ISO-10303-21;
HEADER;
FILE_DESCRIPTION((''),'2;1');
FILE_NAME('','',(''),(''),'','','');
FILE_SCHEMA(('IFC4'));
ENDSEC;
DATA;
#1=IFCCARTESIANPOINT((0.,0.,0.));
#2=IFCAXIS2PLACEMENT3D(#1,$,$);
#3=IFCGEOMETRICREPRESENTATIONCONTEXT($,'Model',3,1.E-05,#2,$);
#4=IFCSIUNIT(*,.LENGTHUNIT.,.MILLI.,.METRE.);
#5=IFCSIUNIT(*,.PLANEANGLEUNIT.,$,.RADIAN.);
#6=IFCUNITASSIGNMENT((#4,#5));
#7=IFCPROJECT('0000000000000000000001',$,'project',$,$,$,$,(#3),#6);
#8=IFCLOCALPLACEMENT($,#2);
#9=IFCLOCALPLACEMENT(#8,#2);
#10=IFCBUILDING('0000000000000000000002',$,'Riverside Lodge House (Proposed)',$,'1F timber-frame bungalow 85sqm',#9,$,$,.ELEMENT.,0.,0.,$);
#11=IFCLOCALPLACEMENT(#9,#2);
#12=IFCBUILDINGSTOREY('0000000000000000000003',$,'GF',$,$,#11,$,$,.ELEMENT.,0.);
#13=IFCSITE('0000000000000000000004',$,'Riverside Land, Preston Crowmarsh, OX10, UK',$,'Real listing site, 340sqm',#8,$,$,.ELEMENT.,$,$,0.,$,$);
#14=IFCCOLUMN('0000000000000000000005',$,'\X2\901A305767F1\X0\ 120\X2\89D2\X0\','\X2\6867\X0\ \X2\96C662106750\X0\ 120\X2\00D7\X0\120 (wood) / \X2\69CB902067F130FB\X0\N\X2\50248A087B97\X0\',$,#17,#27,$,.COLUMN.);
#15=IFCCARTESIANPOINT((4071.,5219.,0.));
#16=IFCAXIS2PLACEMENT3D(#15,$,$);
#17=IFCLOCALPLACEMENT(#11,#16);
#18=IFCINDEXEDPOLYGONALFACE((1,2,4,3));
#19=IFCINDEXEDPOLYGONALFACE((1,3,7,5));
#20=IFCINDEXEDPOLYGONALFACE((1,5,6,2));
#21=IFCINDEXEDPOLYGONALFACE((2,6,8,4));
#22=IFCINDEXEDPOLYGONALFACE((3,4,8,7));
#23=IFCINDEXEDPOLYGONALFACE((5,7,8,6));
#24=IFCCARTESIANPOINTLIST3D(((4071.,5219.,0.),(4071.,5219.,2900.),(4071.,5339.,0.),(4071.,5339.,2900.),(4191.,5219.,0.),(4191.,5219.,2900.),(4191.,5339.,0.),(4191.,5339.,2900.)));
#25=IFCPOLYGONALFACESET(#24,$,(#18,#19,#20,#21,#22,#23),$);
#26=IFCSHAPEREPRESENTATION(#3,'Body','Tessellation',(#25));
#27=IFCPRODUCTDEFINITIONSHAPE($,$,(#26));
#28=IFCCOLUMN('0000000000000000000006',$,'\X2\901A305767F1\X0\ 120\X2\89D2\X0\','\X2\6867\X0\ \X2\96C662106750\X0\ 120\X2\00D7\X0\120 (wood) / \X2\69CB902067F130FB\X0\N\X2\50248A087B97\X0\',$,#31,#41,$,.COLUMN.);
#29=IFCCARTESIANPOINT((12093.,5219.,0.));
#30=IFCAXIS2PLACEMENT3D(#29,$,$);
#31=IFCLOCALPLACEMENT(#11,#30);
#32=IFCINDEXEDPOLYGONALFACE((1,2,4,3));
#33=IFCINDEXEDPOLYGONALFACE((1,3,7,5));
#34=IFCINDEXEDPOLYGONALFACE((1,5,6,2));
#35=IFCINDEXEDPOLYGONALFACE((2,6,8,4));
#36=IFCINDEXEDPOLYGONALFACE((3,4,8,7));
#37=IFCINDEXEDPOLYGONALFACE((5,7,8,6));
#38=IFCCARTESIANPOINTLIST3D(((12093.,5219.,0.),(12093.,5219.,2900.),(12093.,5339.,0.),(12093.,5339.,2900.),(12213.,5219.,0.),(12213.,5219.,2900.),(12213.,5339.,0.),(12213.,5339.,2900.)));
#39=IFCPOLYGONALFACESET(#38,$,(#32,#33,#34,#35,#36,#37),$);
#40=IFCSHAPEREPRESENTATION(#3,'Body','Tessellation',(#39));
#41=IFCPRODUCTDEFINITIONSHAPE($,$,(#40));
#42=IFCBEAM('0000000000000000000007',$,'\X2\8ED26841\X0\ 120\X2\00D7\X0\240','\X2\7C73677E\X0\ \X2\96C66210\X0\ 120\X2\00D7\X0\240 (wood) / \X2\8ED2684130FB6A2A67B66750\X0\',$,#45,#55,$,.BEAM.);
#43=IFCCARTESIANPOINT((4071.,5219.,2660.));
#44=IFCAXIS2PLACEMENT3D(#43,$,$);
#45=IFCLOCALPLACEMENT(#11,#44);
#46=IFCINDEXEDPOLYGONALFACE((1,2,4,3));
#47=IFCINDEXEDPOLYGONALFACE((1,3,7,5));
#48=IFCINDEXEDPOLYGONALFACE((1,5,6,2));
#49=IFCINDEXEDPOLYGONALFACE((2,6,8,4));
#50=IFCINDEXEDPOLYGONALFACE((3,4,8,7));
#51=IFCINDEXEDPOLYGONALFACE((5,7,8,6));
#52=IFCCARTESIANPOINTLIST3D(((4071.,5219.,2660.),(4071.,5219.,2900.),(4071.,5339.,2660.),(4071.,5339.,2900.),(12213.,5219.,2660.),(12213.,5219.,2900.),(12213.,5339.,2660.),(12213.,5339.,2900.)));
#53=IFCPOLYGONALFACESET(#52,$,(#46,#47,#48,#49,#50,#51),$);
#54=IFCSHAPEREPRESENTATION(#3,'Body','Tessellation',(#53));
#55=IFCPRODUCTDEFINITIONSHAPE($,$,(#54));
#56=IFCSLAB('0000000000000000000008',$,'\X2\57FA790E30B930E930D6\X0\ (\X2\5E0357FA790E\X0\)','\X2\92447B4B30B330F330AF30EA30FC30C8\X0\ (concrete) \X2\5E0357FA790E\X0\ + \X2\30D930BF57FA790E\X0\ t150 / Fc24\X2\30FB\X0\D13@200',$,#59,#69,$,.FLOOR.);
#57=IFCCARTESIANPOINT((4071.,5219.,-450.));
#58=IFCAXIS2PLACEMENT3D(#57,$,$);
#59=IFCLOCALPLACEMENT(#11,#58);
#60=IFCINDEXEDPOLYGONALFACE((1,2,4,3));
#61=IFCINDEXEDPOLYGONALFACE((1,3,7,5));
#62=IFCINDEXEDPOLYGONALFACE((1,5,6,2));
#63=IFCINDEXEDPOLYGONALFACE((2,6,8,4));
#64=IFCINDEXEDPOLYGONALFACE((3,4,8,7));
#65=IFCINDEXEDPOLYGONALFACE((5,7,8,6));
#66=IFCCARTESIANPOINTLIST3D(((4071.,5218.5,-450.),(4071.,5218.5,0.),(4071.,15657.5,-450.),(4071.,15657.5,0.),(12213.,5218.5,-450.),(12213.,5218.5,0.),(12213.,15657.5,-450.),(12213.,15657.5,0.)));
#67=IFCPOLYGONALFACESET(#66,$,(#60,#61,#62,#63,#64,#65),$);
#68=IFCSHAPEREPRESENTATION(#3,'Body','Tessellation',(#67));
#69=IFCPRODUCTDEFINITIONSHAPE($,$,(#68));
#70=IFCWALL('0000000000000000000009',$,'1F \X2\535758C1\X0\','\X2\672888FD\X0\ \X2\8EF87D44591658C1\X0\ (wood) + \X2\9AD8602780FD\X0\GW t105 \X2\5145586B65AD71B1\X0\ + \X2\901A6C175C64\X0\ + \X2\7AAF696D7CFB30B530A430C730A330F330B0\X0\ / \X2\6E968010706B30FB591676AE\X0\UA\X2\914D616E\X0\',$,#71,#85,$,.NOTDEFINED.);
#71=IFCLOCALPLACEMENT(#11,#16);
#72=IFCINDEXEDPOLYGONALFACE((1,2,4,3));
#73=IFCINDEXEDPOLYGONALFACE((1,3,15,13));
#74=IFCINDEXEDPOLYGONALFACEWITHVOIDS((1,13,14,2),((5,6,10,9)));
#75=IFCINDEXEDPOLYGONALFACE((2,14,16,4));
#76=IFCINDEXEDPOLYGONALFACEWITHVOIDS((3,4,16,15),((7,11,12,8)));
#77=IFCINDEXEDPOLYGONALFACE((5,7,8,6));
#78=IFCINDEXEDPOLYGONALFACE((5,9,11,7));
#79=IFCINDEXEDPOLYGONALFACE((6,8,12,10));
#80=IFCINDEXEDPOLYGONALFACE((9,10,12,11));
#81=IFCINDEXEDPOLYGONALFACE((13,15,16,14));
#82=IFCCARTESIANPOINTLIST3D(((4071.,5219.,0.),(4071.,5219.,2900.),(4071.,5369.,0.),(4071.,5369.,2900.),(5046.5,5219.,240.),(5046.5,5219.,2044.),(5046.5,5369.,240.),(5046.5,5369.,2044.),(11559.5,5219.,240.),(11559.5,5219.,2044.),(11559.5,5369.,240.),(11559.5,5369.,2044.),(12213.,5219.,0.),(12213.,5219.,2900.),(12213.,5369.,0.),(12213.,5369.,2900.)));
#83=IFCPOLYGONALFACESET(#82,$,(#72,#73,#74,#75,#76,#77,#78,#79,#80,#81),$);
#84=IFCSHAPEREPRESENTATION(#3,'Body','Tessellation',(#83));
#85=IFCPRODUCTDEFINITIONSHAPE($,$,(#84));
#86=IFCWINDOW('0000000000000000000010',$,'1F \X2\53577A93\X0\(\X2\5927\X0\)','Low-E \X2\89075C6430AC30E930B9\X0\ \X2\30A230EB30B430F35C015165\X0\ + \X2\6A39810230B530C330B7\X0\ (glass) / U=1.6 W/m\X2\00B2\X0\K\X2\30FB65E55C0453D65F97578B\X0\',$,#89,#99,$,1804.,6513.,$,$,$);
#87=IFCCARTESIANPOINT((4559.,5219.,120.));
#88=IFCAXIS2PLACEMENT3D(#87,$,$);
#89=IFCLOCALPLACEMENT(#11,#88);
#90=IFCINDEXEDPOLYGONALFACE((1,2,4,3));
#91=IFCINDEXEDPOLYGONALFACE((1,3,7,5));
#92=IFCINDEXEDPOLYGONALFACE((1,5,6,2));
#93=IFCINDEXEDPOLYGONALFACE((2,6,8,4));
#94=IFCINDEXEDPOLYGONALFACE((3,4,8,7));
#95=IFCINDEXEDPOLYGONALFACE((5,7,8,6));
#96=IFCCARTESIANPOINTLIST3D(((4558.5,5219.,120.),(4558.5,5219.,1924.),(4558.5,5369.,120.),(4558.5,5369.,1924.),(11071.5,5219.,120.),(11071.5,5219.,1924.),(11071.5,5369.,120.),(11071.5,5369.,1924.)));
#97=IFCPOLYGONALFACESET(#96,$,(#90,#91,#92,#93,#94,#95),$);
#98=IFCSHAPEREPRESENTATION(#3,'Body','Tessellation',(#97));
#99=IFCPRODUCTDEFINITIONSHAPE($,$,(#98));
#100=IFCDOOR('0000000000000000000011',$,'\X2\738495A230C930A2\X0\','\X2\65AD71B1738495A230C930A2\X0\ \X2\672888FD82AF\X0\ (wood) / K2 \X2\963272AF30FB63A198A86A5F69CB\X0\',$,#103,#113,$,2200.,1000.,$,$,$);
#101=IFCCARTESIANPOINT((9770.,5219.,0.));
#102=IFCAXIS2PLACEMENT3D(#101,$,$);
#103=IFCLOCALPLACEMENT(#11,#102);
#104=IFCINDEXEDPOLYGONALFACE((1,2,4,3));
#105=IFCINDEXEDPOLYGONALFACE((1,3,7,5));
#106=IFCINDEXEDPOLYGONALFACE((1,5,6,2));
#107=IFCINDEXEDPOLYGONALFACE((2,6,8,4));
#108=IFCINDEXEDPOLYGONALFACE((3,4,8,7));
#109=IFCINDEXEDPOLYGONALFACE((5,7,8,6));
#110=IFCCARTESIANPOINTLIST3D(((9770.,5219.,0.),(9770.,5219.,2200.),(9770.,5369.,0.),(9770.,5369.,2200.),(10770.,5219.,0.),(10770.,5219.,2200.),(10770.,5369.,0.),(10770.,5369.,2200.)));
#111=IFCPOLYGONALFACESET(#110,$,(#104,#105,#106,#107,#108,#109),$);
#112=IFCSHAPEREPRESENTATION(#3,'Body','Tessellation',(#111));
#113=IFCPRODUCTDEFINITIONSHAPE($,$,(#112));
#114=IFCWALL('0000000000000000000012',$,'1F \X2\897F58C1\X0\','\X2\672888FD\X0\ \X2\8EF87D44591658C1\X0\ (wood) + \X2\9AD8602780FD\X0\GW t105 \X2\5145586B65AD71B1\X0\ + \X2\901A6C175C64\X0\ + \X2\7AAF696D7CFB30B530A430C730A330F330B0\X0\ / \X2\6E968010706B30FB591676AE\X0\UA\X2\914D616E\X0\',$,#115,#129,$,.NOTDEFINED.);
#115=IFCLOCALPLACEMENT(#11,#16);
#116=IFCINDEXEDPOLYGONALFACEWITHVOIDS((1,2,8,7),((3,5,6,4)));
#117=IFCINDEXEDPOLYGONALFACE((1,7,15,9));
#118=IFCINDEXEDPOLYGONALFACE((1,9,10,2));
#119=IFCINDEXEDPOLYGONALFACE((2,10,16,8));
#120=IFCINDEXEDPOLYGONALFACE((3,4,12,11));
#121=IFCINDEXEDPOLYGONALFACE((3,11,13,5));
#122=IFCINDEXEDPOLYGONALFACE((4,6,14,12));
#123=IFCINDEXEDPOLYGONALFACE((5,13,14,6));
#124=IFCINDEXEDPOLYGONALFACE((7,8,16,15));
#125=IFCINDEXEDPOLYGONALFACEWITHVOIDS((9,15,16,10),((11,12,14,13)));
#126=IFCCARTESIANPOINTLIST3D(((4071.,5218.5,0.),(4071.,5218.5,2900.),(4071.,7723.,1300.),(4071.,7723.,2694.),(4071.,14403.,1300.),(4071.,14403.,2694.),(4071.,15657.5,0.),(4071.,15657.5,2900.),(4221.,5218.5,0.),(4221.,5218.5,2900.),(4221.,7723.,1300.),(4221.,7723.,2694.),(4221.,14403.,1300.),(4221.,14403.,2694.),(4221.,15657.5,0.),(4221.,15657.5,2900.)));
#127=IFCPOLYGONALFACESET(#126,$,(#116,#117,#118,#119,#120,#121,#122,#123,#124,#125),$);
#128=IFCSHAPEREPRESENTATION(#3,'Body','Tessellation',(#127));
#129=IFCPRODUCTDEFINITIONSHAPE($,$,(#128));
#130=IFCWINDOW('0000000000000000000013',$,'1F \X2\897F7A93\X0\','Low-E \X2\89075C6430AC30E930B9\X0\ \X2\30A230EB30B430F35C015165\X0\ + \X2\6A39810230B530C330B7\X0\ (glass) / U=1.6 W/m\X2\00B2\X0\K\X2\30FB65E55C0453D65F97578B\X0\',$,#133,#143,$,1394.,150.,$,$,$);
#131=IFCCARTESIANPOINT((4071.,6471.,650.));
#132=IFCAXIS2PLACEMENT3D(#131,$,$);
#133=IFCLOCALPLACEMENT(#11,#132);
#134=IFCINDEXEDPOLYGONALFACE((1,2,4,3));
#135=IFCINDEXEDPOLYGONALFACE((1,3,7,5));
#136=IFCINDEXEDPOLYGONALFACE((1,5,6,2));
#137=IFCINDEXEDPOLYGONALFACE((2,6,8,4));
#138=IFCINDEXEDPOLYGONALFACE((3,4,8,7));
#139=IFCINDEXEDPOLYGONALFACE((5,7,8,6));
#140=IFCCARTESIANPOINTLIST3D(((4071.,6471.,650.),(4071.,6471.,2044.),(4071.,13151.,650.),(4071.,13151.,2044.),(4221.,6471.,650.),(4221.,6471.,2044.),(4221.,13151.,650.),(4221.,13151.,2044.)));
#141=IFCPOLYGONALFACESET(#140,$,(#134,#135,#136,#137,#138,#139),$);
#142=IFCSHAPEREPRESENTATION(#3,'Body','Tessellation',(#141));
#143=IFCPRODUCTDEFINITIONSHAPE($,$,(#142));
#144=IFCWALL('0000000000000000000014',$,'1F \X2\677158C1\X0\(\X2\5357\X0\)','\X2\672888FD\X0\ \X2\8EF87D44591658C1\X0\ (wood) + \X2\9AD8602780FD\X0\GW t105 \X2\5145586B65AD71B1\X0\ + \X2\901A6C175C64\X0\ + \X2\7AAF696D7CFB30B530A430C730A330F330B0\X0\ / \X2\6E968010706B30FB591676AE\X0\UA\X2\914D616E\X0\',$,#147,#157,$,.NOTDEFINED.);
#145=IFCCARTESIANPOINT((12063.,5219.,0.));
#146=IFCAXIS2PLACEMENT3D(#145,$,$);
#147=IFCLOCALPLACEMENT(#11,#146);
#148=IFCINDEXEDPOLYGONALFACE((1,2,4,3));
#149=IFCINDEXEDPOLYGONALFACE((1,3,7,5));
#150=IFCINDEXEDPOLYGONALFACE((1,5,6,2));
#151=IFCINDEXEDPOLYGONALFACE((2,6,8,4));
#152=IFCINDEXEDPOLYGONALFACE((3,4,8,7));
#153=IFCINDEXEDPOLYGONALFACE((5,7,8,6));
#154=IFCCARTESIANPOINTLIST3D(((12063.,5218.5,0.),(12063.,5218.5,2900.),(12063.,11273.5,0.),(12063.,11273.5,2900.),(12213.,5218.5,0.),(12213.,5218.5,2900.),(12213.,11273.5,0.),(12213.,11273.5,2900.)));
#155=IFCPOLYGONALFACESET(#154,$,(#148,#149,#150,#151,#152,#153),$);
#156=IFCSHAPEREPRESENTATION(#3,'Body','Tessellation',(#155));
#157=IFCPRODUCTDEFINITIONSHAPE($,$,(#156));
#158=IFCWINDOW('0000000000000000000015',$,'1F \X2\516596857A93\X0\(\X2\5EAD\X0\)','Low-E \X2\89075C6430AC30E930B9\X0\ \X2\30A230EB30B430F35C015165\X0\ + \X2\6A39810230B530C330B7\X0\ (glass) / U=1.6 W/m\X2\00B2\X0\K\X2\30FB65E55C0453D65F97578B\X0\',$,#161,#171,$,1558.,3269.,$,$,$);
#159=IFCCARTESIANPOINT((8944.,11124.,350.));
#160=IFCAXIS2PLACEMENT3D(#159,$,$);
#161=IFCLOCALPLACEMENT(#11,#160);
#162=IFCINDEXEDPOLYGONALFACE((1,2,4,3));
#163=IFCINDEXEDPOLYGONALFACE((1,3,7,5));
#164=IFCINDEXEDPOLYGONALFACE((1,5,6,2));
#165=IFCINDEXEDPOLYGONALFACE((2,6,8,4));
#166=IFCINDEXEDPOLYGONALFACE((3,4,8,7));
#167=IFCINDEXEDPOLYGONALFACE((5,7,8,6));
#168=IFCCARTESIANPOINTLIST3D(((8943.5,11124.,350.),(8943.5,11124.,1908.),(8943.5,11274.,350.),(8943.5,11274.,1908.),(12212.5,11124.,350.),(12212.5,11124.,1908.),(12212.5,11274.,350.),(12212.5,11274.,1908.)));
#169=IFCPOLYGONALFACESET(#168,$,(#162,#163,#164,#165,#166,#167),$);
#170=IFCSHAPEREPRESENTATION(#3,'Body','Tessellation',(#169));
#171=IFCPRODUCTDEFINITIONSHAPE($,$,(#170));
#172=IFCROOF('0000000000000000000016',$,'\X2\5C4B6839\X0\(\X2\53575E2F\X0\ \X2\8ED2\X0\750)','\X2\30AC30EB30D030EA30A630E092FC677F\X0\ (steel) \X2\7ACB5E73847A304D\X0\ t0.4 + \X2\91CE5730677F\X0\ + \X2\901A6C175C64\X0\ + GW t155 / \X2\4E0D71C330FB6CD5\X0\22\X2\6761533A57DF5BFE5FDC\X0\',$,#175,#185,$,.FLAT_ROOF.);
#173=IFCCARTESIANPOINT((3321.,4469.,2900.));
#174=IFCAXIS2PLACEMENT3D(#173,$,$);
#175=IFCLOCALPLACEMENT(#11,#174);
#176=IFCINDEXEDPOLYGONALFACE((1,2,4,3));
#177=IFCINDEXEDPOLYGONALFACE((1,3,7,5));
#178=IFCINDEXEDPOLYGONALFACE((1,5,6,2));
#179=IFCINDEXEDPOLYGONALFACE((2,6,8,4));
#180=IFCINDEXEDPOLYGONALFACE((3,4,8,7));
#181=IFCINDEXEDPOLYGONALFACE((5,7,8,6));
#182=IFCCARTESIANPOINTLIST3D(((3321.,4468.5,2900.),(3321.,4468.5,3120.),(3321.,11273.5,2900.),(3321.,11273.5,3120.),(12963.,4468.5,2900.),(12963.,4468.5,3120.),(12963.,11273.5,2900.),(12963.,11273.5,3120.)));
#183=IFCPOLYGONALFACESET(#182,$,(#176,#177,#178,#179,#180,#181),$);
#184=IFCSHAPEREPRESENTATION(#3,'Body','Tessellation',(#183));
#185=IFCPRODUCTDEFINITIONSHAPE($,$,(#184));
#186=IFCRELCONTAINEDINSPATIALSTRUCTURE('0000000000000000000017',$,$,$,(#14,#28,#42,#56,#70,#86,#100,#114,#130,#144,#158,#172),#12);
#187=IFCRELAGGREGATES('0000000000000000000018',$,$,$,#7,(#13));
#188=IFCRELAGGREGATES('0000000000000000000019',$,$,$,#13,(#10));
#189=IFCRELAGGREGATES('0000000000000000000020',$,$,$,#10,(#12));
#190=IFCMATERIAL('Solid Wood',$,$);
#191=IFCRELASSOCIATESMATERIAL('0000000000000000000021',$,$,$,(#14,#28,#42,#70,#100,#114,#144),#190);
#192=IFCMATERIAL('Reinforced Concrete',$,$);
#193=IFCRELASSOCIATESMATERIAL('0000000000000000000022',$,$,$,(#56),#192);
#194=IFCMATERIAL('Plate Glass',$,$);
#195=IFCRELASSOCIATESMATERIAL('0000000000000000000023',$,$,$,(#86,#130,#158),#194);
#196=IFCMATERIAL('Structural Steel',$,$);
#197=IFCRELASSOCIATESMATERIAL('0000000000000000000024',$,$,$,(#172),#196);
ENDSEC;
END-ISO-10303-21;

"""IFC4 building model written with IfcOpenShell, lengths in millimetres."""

from ifc_helpers import new_model, si_unit, frame, frame_2d, origin, place, context, project, spatial, rectangle, extrude, material, element, fill, save


model = new_model("IFC4")

# Units and contexts
model_context = context("Model", 3, precision=1e-05, world=origin())
ifc_project = project(units=[si_unit("LENGTHUNIT", "METRE", prefix="MILLI"), si_unit("PLANEANGLEUNIT", "RADIAN")], contexts=[model_context])

# Site, building, storey
site_placement = place(None, origin())
site = spatial("IfcSite", under=ifc_project, at=site_placement, Name="Riverside Land, Preston Crowmarsh, OX10, UK", ObjectType="Real listing site, 340sqm", CompositionType="ELEMENT", RefElevation=0.0)
building_placement = place(site_placement, origin())
building = spatial("IfcBuilding", under=site, at=building_placement, Name="Riverside Lodge House (Proposed)", ObjectType="1F timber-frame bungalow 85sqm", CompositionType="ELEMENT", ElevationOfRefHeight=0.0, ElevationOfTerrain=0.0)
storey_placement = place(building_placement, origin())
storey = spatial("IfcBuildingStorey", under=building, at=storey_placement, Name="GF", CompositionType="ELEMENT", Elevation=0.0)

# Columns
ifc_material_1 = material(Name="Solid Wood")
column_1_placement = place(storey_placement, frame((4071.0, 5219.0, 0.0)))
element("IfcColumn", 1, at=column_1_placement, inside=storey, material=ifc_material_1, Name="通し柱 120角", Description="桧 集成材 120×120 (wood) / 構造柱・N値計算", PredefinedType="COLUMN", context=model_context, shape_type="SweptSolid", body=[
    extrude(rectangle(XDim=120.0, YDim=120.0, at=frame_2d((60.0, 60.0))), frame((4071.0, 5219.0, 0.0)), (0.0, 0.0, 1.0), 2900.0),
])
column_2_placement = place(storey_placement, frame((12093.0, 5219.0, 0.0)))
element("IfcColumn", 2, at=column_2_placement, inside=storey, material=ifc_material_1, Name="通し柱 120角", Description="桧 集成材 120×120 (wood) / 構造柱・N値計算", PredefinedType="COLUMN", context=model_context, shape_type="SweptSolid", body=[
    extrude(rectangle(XDim=120.0, YDim=120.0, at=frame_2d((60.0, 60.0))), frame((12093.0, 5219.0, 0.0)), (0.0, 0.0, 1.0), 2900.0),
])

# Beam
beam_1_placement = place(storey_placement, frame((4071.0, 5219.0, 2660.0)))
element("IfcBeam", 3, at=beam_1_placement, inside=storey, material=ifc_material_1, Name="軒桁 120×240", Description="米松 集成 120×240 (wood) / 軒桁・横架材", PredefinedType="BEAM", context=model_context, shape_type="SweptSolid", body=[
    extrude(rectangle(XDim=8142.0, YDim=120.0, at=frame_2d((4071.0, 60.0))), frame((4071.0, 5219.0, 2660.0)), (0.0, 0.0, 1.0), 240.0),
])

# Slab
ifc_material_2 = material(Name="Reinforced Concrete")
slab_1_placement = place(storey_placement, frame((4071.0, 5219.0, -450.0)))
element("IfcSlab", 4, at=slab_1_placement, inside=storey, material=ifc_material_2, Name="基礎スラブ (布基礎)", Description="鉄筋コンクリート (concrete) 布基礎 + ベタ基礎 t150 / Fc24・D13@200", PredefinedType="FLOOR", context=model_context, shape_type="SweptSolid", body=[
    extrude(rectangle(XDim=8142.0, YDim=10439.0, at=frame_2d((4071.0, 5219.0))), frame((4071.0, 5219.0, -450.0)), (0.0, 0.0, 1.0), 450.0),
])

# Wall, openings, window, door
wall_1_placement = place(storey_placement, frame((4071.0, 5219.0, 0.0)))
wall_1 = element("IfcWall", 5, at=wall_1_placement, inside=storey, material=ifc_material_1, Name="1F 南壁", Description="木製 軸組外壁 (wood) + 高性能GW t105 充填断熱 + 通気層 + 窯業系サイディング / 準耐火・外皮UA配慮", PredefinedType="NOTDEFINED", context=model_context, shape_type="SweptSolid", body=[
    extrude(rectangle(XDim=8142.0, YDim=150.0, at=frame_2d((4071.0, 75.0))), frame((4071.0, 5219.0, 0.0)), (0.0, 0.0, 1.0), 2900.0),
])
opening_1_placement = place(storey_placement, frame((4559.0, 5219.0, 120.0)))
opening_1 = element("IfcOpeningElement", 6, at=opening_1_placement, cuts=wall_1, PredefinedType="NOTDEFINED", context=model_context, shape_type="SweptSolid", body=[
    extrude(rectangle(XDim=6513.0, YDim=150.0, at=frame_2d((3256.0, 75.0))), frame((4559.0, 5219.0, 120.0)), (0.0, 0.0, 1.0), 1804.0),
])
opening_2_placement = place(storey_placement, frame((9770.0, 5219.0, 0.0)))
opening_2 = element("IfcOpeningElement", 7, at=opening_2_placement, cuts=wall_1, PredefinedType="NOTDEFINED", context=model_context, shape_type="SweptSolid", body=[
    extrude(rectangle(XDim=1000.0, YDim=150.0, at=frame_2d((500.0, 75.0))), frame((9770.0, 5219.0, 0.0)), (0.0, 0.0, 1.0), 2200.0),
])
ifc_material_3 = material(Name="Plate Glass")
window_1_placement = place(storey_placement, frame((4559.0, 5219.0, 120.0)))
window_1 = element("IfcWindow", 8, at=window_1_placement, inside=storey, material=ifc_material_3, Name="1F 南窓(大)", Description="Low-E 複層ガラス アルゴン封入 + 樹脂サッシ (glass) / U=1.6 W/m²K・日射取得型", OverallHeight=1804.0, OverallWidth=6513.0, context=model_context, shape_type="SweptSolid", body=[
    extrude(rectangle(XDim=6513.0, YDim=150.0, at=frame_2d((3256.0, 75.0))), frame((4559.0, 5219.0, 120.0)), (0.0, 0.0, 1.0), 1804.0),
])
fill(opening_1, window_1)
door_1_placement = place(storey_placement, frame((9770.0, 5219.0, 0.0)))
door_1 = element("IfcDoor", 9, at=door_1_placement, inside=storey, material=ifc_material_1, Name="玄関ドア", Description="断熱玄関ドア 木製芯 (wood) / K2 防犯・採風機構", OverallHeight=2200.0, OverallWidth=1000.0, context=model_context, shape_type="SweptSolid", body=[
    extrude(rectangle(XDim=1000.0, YDim=150.0, at=frame_2d((500.0, 75.0))), frame((9770.0, 5219.0, 0.0)), (0.0, 0.0, 1.0), 2200.0),
])
fill(opening_2, door_1)

# Walls, openings, windows
wall_2_placement = place(storey_placement, frame((4071.0, 5219.0, 0.0)))
wall_2 = element("IfcWall", 10, at=wall_2_placement, inside=storey, material=ifc_material_1, Name="1F 西壁", Description="木製 軸組外壁 (wood) + 高性能GW t105 充填断熱 + 通気層 + 窯業系サイディング / 準耐火・外皮UA配慮", PredefinedType="NOTDEFINED", context=model_context, shape_type="SweptSolid", body=[
    extrude(rectangle(XDim=150.0, YDim=10439.0, at=frame_2d((75.0, 5219.0))), frame((4071.0, 5219.0, 0.0)), (0.0, 0.0, 1.0), 2900.0),
])
opening_3_placement = place(storey_placement, frame((4071.0, 6471.0, 650.0)))
opening_3 = element("IfcOpeningElement", 11, at=opening_3_placement, cuts=wall_2, PredefinedType="NOTDEFINED", context=model_context, shape_type="SweptSolid", body=[
    extrude(rectangle(XDim=150.0, YDim=6680.0, at=frame_2d((75.0, 3340.0))), frame((4071.0, 6471.0, 650.0)), (0.0, 0.0, 1.0), 1394.0),
])
window_2_placement = place(storey_placement, frame((4071.0, 6471.0, 650.0)))
window_2 = element("IfcWindow", 12, at=window_2_placement, inside=storey, material=ifc_material_3, Name="1F 西窓", Description="Low-E 複層ガラス アルゴン封入 + 樹脂サッシ (glass) / U=1.6 W/m²K・日射取得型", OverallHeight=1394.0, OverallWidth=150.0, context=model_context, shape_type="SweptSolid", body=[
    extrude(rectangle(XDim=150.0, YDim=6680.0, at=frame_2d((75.0, 3340.0))), frame((4071.0, 6471.0, 650.0)), (0.0, 0.0, 1.0), 1394.0),
])
fill(opening_3, window_2)
wall_3_placement = place(storey_placement, frame((12063.0, 5219.0, 0.0)))
wall_3 = element("IfcWall", 13, at=wall_3_placement, inside=storey, material=ifc_material_1, Name="1F 東壁(南)", Description="木製 軸組外壁 (wood) + 高性能GW t105 充填断熱 + 通気層 + 窯業系サイディング / 準耐火・外皮UA配慮", PredefinedType="NOTDEFINED", context=model_context, shape_type="SweptSolid", body=[
    extrude(rectangle(XDim=150.0, YDim=6055.0, at=frame_2d((75.0, 3027.0))), frame((12063.0, 5219.0, 0.0)), (0.0, 0.0, 1.0), 2900.0),
])
opening_4_placement = place(storey_placement, frame((8944.0, 11124.0, 350.0)))
opening_4 = element("IfcOpeningElement", 14, at=opening_4_placement, cuts=wall_3, PredefinedType="NOTDEFINED", context=model_context, shape_type="SweptSolid", body=[
    extrude(rectangle(XDim=3269.0, YDim=150.0, at=frame_2d((1634.0, 75.0))), frame((8944.0, 11124.0, 350.0)), (0.0, 0.0, 1.0), 1558.0),
])
window_3_placement = place(storey_placement, frame((8944.0, 11124.0, 350.0)))
window_3 = element("IfcWindow", 15, at=window_3_placement, inside=storey, material=ifc_material_3, Name="1F 入隅窓(庭)", Description="Low-E 複層ガラス アルゴン封入 + 樹脂サッシ (glass) / U=1.6 W/m²K・日射取得型", OverallHeight=1558.0, OverallWidth=3269.0, context=model_context, shape_type="SweptSolid", body=[
    extrude(rectangle(XDim=3269.0, YDim=150.0, at=frame_2d((1634.0, 75.0))), frame((8944.0, 11124.0, 350.0)), (0.0, 0.0, 1.0), 1558.0),
])
fill(opening_4, window_3)

# Roof
ifc_material_4 = material(Name="Structural Steel")
roof_placement = place(storey_placement, frame((3321.0, 4469.0, 2900.0)))
element("IfcRoof", 16, at=roof_placement, inside=storey, material=ifc_material_4, Name="屋根(南帯 軒750)", Description="ガルバリウム鋼板 (steel) 立平葺き t0.4 + 野地板 + 通気層 + GW t155 / 不燃・法22条区域対応", PredefinedType="FLAT_ROOF", context=model_context, shape_type="SweptSolid", body=[
    extrude(rectangle(XDim=9642.0, YDim=6805.0, at=frame_2d((4821.0, 3402.0))), frame((3321.0, 4469.0, 2900.0)), (0.0, 0.0, 1.0), 220.0),
])

save(model, "model.ifc")
